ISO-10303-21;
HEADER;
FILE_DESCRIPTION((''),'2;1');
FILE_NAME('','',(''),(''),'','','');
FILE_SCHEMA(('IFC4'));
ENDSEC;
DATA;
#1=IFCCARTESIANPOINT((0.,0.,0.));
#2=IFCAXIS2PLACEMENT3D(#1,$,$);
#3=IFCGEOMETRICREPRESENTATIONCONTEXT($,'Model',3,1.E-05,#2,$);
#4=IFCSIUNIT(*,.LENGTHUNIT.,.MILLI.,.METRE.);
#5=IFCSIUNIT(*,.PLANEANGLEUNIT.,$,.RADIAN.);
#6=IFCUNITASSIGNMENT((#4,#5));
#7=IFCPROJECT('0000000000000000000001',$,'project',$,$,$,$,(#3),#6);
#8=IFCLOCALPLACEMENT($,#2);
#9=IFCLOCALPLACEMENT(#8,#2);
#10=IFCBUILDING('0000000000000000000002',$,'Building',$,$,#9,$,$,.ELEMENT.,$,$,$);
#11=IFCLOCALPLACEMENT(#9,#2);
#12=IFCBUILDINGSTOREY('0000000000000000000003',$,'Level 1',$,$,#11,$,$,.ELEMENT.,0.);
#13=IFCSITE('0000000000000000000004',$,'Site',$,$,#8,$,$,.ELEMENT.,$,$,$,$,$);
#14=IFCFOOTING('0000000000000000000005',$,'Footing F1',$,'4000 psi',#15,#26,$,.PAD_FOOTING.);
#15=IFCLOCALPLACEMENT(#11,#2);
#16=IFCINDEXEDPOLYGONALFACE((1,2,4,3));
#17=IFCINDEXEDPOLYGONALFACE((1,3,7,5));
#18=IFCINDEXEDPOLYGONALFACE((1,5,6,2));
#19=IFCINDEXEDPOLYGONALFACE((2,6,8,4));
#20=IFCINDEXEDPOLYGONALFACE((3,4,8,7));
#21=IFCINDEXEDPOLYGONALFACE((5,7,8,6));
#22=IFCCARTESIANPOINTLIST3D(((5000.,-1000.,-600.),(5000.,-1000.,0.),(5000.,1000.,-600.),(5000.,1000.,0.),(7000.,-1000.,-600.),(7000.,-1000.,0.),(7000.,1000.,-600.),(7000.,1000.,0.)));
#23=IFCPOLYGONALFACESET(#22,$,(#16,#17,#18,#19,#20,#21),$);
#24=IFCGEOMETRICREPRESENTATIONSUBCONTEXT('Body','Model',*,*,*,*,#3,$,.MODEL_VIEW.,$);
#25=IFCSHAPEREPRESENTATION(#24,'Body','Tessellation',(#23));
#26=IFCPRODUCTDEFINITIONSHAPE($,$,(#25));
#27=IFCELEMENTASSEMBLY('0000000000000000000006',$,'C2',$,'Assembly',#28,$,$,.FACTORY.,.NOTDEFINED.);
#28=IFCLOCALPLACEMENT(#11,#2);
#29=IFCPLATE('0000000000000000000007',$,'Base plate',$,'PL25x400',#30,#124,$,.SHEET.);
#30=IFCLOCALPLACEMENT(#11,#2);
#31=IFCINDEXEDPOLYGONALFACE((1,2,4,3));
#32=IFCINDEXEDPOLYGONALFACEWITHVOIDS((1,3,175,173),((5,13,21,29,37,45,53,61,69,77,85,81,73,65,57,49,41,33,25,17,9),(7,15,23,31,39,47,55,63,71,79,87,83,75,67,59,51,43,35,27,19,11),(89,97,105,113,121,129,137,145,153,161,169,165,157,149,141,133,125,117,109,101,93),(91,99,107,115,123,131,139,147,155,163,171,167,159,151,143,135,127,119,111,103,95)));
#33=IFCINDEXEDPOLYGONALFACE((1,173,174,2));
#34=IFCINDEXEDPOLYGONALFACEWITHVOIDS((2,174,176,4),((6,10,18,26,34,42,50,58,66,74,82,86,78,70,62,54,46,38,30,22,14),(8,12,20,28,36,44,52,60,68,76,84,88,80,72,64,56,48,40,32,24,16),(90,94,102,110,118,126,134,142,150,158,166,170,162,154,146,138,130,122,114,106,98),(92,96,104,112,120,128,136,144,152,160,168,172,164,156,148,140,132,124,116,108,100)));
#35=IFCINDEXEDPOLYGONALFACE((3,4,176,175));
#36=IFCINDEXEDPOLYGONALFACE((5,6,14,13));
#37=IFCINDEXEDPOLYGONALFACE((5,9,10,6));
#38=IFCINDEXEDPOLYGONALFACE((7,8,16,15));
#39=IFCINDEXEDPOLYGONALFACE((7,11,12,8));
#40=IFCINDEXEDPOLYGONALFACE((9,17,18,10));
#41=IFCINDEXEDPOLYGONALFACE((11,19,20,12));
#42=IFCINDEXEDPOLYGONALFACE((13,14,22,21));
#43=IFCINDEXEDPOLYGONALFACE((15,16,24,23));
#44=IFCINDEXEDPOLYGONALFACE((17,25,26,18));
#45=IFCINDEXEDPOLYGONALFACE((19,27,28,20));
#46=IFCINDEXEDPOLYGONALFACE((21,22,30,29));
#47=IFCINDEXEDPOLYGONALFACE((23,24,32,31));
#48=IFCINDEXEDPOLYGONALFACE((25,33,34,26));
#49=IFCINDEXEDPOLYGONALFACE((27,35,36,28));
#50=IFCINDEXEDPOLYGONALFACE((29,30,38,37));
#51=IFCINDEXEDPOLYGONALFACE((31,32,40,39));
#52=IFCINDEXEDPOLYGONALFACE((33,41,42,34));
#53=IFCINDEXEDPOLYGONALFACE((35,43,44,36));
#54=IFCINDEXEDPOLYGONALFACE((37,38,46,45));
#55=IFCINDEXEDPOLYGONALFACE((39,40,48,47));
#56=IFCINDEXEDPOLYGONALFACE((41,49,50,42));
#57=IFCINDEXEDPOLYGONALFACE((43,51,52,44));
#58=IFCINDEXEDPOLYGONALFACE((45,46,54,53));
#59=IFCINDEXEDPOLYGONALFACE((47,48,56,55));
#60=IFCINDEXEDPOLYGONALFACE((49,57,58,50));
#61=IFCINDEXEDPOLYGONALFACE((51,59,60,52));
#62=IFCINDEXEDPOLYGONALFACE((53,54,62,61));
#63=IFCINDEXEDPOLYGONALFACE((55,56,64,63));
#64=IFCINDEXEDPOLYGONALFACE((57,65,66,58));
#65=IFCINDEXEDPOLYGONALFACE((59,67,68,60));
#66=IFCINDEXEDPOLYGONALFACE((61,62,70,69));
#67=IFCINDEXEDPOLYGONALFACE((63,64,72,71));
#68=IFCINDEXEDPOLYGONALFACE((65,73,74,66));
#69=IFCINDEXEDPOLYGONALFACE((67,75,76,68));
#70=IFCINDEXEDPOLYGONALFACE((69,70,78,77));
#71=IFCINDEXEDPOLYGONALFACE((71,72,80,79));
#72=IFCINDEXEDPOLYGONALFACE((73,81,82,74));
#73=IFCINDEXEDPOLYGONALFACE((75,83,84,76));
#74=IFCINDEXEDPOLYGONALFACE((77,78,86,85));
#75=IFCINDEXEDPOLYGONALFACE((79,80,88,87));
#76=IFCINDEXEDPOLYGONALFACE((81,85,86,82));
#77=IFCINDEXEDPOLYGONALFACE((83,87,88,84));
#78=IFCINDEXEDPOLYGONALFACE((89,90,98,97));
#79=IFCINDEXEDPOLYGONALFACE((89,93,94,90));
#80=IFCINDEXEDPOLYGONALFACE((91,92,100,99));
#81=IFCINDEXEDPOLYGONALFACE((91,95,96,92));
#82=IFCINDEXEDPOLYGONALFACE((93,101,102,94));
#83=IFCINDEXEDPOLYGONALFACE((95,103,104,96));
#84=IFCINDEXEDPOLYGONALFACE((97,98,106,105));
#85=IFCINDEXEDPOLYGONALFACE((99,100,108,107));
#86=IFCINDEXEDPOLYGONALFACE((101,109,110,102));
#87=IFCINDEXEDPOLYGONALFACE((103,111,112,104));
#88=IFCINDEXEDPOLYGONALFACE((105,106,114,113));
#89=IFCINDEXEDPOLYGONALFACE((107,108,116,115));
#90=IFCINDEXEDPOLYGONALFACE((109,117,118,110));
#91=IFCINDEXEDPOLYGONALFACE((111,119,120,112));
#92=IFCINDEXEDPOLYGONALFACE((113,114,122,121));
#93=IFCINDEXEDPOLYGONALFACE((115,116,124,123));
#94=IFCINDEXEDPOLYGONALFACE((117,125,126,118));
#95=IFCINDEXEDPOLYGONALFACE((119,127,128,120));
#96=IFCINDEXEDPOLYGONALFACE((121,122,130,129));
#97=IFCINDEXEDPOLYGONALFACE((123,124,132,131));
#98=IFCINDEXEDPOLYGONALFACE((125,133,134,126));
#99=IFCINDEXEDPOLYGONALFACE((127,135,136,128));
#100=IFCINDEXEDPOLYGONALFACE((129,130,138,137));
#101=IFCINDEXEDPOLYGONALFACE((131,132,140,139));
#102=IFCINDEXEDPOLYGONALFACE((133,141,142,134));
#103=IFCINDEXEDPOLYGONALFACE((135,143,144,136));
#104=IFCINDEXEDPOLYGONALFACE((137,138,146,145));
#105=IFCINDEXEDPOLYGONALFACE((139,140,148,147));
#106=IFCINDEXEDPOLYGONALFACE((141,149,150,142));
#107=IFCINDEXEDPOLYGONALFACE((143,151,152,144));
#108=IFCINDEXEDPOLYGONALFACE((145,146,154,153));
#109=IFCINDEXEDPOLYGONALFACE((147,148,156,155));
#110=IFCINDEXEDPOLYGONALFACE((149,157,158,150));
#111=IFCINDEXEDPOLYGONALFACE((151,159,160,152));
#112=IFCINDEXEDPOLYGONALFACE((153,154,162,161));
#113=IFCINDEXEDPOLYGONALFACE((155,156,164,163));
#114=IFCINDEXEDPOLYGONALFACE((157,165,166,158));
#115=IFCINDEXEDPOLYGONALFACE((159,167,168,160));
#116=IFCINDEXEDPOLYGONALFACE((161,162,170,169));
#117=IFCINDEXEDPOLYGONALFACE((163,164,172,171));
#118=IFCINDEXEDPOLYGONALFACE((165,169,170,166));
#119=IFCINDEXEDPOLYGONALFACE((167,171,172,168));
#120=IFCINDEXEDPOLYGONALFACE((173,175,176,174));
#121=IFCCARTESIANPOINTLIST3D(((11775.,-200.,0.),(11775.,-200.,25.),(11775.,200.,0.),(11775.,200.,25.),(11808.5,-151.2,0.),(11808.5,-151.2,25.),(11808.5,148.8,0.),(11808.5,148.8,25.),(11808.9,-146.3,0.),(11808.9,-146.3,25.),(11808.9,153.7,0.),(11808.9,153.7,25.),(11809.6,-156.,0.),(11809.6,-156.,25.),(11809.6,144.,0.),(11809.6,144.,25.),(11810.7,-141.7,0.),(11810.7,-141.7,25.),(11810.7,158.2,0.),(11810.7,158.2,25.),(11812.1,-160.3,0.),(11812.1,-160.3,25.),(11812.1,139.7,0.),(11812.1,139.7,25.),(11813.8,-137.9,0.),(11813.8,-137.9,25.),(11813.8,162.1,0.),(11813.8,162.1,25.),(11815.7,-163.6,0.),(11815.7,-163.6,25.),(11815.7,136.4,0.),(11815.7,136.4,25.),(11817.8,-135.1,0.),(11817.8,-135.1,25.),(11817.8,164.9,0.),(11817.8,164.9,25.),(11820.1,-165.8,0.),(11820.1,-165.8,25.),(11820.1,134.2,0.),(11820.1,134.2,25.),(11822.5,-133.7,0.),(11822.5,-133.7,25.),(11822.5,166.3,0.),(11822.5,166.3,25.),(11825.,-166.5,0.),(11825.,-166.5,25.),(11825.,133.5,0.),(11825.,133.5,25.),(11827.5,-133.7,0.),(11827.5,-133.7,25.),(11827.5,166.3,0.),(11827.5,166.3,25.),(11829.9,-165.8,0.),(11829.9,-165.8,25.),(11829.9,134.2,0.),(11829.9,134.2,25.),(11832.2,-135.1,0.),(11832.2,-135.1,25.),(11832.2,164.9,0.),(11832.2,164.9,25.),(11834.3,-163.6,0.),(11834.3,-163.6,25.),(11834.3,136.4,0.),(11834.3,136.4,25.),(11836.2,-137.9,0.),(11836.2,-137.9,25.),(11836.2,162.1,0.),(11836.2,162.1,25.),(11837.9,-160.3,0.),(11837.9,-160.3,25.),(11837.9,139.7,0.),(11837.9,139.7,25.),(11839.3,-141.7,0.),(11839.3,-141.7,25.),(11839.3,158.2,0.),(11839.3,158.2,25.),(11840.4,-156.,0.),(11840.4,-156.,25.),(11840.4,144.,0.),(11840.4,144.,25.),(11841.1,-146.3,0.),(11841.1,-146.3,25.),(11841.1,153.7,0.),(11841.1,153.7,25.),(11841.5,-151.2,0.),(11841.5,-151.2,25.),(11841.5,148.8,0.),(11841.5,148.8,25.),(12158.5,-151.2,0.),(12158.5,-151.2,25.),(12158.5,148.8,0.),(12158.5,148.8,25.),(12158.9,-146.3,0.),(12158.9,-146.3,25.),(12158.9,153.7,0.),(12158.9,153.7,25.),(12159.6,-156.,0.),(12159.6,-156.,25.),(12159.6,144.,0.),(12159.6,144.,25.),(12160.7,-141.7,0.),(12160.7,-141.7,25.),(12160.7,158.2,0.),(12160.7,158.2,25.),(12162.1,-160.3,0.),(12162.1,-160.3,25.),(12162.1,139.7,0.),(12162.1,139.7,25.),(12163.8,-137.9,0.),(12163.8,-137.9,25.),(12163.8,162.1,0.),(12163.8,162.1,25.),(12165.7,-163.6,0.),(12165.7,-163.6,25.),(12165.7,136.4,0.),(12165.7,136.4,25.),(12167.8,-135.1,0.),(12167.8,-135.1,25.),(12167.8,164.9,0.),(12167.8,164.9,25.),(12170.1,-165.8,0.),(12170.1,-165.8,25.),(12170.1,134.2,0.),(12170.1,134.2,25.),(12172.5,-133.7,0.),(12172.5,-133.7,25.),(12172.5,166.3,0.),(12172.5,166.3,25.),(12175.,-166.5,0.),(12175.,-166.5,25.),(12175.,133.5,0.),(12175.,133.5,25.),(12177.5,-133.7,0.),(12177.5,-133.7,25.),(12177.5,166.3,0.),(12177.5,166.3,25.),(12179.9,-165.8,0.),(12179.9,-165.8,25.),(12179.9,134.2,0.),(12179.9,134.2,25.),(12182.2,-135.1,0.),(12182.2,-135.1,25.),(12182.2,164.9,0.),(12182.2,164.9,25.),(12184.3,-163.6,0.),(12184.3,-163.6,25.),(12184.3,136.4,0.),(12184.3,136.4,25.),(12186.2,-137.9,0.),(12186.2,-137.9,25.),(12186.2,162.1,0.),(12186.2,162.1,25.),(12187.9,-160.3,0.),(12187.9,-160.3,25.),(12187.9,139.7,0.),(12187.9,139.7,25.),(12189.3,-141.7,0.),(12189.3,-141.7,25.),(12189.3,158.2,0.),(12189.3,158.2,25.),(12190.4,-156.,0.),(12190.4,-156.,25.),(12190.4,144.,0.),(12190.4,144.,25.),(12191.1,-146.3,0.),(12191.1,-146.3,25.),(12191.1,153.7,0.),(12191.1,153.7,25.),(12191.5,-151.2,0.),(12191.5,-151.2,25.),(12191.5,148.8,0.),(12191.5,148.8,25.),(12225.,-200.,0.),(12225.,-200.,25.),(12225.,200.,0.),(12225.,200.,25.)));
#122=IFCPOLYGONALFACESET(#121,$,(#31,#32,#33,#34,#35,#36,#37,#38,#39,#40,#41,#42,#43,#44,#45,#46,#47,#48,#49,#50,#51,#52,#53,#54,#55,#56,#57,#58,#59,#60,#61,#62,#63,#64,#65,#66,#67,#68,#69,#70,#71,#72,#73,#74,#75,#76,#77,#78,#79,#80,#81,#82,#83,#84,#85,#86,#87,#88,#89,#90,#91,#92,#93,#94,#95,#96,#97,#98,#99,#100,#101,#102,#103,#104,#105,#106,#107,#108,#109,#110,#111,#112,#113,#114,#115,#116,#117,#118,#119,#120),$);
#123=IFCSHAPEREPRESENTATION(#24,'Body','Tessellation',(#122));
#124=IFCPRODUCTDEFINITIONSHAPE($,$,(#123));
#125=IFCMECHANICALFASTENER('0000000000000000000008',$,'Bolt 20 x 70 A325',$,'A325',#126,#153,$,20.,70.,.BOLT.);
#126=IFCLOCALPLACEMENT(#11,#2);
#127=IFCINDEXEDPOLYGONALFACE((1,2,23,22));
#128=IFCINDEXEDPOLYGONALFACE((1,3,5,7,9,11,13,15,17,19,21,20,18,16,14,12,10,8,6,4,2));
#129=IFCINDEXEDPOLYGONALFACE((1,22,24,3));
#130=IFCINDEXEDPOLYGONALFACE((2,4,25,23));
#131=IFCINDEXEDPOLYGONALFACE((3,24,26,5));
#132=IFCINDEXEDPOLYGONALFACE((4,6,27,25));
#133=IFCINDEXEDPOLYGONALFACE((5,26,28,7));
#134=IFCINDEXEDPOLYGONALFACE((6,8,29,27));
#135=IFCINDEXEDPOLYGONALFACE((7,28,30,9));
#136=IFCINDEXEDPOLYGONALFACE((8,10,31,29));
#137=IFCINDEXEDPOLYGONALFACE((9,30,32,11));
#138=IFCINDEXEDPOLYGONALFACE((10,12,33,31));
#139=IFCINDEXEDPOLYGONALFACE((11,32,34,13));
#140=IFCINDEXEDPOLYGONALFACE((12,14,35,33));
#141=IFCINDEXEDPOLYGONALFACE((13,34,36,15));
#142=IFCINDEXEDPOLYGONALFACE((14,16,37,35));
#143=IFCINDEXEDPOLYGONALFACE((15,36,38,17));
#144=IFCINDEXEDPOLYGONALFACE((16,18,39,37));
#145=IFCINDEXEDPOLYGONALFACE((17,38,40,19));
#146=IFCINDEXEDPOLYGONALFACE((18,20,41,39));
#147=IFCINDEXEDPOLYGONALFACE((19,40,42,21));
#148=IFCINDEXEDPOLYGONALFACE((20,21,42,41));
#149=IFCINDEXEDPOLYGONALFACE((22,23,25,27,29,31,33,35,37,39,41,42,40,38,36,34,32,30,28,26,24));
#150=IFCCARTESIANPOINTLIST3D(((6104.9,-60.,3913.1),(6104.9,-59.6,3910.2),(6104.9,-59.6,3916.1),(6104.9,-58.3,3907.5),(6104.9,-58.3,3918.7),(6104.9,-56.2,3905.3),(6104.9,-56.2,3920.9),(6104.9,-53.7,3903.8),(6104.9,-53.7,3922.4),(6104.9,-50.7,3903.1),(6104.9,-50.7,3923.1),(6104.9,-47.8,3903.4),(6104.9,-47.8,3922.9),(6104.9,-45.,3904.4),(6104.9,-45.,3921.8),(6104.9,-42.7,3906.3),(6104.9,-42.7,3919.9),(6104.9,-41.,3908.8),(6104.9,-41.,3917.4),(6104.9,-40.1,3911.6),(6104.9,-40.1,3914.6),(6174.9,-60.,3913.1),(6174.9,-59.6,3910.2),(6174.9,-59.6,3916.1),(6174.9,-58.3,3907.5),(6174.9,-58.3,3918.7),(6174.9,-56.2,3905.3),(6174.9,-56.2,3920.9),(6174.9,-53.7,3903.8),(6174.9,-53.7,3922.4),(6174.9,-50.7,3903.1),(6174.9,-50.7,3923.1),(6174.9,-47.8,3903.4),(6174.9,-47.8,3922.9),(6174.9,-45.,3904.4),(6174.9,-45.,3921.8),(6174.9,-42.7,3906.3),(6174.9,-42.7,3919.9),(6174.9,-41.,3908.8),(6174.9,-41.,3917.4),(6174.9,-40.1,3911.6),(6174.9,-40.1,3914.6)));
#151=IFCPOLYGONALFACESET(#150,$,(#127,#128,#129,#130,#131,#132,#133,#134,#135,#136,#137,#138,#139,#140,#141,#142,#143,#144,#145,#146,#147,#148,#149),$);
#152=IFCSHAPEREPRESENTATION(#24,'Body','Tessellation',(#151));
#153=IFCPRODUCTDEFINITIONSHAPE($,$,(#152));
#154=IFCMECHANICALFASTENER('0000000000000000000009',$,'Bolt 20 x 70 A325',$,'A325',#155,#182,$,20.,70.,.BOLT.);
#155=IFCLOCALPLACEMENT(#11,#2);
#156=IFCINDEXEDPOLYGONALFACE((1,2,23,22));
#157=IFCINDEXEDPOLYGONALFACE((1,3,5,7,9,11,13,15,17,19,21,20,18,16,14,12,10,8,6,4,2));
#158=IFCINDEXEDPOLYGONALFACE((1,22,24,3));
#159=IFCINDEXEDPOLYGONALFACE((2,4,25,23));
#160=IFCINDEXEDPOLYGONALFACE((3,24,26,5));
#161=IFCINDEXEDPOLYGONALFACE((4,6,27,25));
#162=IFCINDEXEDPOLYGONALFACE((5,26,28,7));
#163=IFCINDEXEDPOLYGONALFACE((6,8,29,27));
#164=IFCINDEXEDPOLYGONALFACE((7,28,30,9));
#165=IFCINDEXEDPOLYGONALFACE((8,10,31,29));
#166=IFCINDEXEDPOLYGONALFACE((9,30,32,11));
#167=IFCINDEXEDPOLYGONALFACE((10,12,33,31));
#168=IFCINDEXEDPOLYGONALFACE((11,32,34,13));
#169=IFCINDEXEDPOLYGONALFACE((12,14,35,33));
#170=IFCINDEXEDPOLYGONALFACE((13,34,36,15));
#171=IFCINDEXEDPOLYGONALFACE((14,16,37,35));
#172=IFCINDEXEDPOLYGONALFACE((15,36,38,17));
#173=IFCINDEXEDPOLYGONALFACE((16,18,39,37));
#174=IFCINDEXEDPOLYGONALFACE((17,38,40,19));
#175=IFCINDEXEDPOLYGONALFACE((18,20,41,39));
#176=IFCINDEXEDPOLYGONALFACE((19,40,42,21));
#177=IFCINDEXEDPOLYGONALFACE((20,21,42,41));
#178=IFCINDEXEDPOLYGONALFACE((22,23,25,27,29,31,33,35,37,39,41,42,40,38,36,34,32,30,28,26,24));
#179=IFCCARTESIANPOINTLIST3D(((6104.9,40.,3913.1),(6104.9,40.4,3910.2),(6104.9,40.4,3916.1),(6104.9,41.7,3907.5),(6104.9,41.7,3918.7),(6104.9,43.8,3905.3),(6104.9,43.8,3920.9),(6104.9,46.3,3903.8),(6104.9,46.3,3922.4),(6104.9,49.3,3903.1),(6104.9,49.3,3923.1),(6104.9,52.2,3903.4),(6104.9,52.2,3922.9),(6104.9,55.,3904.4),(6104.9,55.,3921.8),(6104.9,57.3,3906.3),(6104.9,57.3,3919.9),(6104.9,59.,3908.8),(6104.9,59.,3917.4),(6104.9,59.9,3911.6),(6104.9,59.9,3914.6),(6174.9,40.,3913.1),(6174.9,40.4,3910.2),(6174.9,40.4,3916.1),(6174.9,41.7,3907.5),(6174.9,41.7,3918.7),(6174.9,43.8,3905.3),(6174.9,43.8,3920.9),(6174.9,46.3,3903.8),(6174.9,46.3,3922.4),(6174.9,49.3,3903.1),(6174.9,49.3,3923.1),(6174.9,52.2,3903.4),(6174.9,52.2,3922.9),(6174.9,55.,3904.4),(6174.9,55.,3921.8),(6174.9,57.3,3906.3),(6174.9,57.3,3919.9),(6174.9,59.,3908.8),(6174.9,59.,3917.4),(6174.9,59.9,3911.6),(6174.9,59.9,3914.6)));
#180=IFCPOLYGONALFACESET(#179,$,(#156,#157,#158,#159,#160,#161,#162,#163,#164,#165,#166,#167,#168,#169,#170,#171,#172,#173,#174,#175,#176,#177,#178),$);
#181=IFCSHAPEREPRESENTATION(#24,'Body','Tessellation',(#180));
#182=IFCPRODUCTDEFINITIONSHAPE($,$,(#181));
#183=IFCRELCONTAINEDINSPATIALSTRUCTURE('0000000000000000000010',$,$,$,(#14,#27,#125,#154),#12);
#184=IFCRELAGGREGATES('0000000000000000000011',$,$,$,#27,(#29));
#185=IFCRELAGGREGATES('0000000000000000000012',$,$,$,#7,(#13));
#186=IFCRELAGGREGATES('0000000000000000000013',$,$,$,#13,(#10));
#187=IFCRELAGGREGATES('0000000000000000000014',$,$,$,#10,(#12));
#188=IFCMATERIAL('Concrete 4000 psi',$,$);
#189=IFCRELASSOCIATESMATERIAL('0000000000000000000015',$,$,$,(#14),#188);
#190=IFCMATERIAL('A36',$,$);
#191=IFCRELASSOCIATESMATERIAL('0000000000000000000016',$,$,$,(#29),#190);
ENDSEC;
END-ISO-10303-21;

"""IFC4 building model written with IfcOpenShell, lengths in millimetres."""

from ifc_helpers import new_model, si_unit, frame, origin, origin_2d, place, context, subcontext, project, spatial, rectangle, circle, extrude, material, element, aggregate, save


model = new_model("IFC4")

# Units and contexts
model_context = context("Model", 3, precision=1e-05, world=origin())
body_context = subcontext(model_context, "Body", "Model", "MODEL_VIEW")
ifc_project = project(units=[si_unit("LENGTHUNIT", "METRE", prefix="MILLI"), si_unit("PLANEANGLEUNIT", "RADIAN")], contexts=[model_context])

# Site, building, storey
site_placement = place(None, origin())
site = spatial("IfcSite", under=ifc_project, at=site_placement, Name="Site", CompositionType="ELEMENT")
building_placement = place(site_placement, origin())
building = spatial("IfcBuilding", under=site, at=building_placement, Name="Building", CompositionType="ELEMENT")
storey_placement = place(building_placement, origin())
storey = spatial("IfcBuildingStorey", under=building, at=storey_placement, Name="Level 1", CompositionType="ELEMENT", Elevation=0.0)

# Footing
ifc_material_1 = material(Name="Concrete 4000 psi")
footing_placement = place(storey_placement, frame((6000.0, 0.0, -600.0), z_axis=(0.0, 0.0, 1.0), x_axis=(1.0, 0.0, 0.0)))
element("IfcFooting", 1, at=footing_placement, inside=storey, material=ifc_material_1, Name="Footing F1", ObjectType="4000 psi", PredefinedType="PAD_FOOTING", context=body_context, shape_type="SweptSolid", body=[
    extrude(rectangle(XDim=2000.0, YDim=2000.0, at=origin_2d()), origin(), (0.0, 0.0, 1.0), 600.0),
])

# Element assembly, plate, openings
assembly_1_placement = place(storey_placement, origin())
assembly_1 = element("IfcElementAssembly", 2, at=assembly_1_placement, inside=storey, Name="C2", ObjectType="Assembly", AssemblyPlace="FACTORY", PredefinedType="NOTDEFINED")
ifc_material_2 = material(Name="A36")
plate_placement = place(storey_placement, frame((11775.0, 0.0, 12.5), z_axis=(1.0, 0.0, 0.0), x_axis=(0.0, 1.0, 0.0)))
plate = element("IfcPlate", 3, at=plate_placement, material=ifc_material_2, Name="Base plate", ObjectType="PL25x400", PredefinedType="SHEET", context=body_context, shape_type="SweptSolid", body=[
    extrude(rectangle(XDim=400.0, YDim=25.0, at=origin_2d()), origin(), (0.0, 0.0, 1.0), 450.0),
])
opening_1_placement = place(plate_placement, frame((-150.0, -13.5, 50.0), z_axis=(0.0, 1.0, 0.0), x_axis=(-1.0, 0.0, 0.0)))
element("IfcOpeningElement", 4, at=opening_1_placement, cuts=plate, PredefinedType="OPENING", context=body_context, shape_type="SweptSolid", body=[
    extrude(circle(Radius=16.5, at=origin_2d()), origin(), (0.0, 0.0, 1.0), 27.0),
])
opening_2_placement = place(plate_placement, frame((150.0, -13.5, 50.0), z_axis=(0.0, 1.0, 0.0), x_axis=(-1.0, 0.0, 0.0)))
element("IfcOpeningElement", 5, at=opening_2_placement, cuts=plate, PredefinedType="OPENING", context=body_context, shape_type="SweptSolid", body=[
    extrude(circle(Radius=16.5, at=origin_2d()), origin(), (0.0, 0.0, 1.0), 27.0),
])
opening_3_placement = place(plate_placement, frame((-150.0, -13.5, 400.0), z_axis=(0.0, 1.0, 0.0), x_axis=(-1.0, 0.0, 0.0)))
element("IfcOpeningElement", 6, at=opening_3_placement, cuts=plate, PredefinedType="OPENING", context=body_context, shape_type="SweptSolid", body=[
    extrude(circle(Radius=16.5, at=origin_2d()), origin(), (0.0, 0.0, 1.0), 27.0),
])
opening_4_placement = place(plate_placement, frame((150.0, -13.5, 400.0), z_axis=(0.0, 1.0, 0.0), x_axis=(-1.0, 0.0, 0.0)))
element("IfcOpeningElement", 7, at=opening_4_placement, cuts=plate, PredefinedType="OPENING", context=body_context, shape_type="SweptSolid", body=[
    extrude(circle(Radius=16.5, at=origin_2d()), origin(), (0.0, 0.0, 1.0), 27.0),
])
aggregate(assembly_1, [plate])

# Mechanical fasteners
for number, where, z_axis, x_axis, name in (
    (8, (6174.9, -50.0, 3913.1), (-1.0, 0.0, 0.0), (0.0, -1.0, 0.0), "Bolt 20 x 70 A325"),
    (9, (6174.9, 50.0, 3913.1), (-1.0, 0.0, 0.0), (0.0, -1.0, 0.0), "Bolt 20 x 70 A325"),
):
    element("IfcMechanicalFastener", number, at=place(storey_placement, frame(where, z_axis=z_axis, x_axis=x_axis)), inside=storey, Name=name, ObjectType="A325", NominalDiameter=20.0, NominalLength=70.0, PredefinedType="BOLT", context=body_context, shape_type="SweptSolid", body=[
        extrude(circle(Radius=10.0, at=origin_2d()), origin(), (0.0, 0.0, 1.0), 70.0),
    ])

save(model, "model.ifc")
